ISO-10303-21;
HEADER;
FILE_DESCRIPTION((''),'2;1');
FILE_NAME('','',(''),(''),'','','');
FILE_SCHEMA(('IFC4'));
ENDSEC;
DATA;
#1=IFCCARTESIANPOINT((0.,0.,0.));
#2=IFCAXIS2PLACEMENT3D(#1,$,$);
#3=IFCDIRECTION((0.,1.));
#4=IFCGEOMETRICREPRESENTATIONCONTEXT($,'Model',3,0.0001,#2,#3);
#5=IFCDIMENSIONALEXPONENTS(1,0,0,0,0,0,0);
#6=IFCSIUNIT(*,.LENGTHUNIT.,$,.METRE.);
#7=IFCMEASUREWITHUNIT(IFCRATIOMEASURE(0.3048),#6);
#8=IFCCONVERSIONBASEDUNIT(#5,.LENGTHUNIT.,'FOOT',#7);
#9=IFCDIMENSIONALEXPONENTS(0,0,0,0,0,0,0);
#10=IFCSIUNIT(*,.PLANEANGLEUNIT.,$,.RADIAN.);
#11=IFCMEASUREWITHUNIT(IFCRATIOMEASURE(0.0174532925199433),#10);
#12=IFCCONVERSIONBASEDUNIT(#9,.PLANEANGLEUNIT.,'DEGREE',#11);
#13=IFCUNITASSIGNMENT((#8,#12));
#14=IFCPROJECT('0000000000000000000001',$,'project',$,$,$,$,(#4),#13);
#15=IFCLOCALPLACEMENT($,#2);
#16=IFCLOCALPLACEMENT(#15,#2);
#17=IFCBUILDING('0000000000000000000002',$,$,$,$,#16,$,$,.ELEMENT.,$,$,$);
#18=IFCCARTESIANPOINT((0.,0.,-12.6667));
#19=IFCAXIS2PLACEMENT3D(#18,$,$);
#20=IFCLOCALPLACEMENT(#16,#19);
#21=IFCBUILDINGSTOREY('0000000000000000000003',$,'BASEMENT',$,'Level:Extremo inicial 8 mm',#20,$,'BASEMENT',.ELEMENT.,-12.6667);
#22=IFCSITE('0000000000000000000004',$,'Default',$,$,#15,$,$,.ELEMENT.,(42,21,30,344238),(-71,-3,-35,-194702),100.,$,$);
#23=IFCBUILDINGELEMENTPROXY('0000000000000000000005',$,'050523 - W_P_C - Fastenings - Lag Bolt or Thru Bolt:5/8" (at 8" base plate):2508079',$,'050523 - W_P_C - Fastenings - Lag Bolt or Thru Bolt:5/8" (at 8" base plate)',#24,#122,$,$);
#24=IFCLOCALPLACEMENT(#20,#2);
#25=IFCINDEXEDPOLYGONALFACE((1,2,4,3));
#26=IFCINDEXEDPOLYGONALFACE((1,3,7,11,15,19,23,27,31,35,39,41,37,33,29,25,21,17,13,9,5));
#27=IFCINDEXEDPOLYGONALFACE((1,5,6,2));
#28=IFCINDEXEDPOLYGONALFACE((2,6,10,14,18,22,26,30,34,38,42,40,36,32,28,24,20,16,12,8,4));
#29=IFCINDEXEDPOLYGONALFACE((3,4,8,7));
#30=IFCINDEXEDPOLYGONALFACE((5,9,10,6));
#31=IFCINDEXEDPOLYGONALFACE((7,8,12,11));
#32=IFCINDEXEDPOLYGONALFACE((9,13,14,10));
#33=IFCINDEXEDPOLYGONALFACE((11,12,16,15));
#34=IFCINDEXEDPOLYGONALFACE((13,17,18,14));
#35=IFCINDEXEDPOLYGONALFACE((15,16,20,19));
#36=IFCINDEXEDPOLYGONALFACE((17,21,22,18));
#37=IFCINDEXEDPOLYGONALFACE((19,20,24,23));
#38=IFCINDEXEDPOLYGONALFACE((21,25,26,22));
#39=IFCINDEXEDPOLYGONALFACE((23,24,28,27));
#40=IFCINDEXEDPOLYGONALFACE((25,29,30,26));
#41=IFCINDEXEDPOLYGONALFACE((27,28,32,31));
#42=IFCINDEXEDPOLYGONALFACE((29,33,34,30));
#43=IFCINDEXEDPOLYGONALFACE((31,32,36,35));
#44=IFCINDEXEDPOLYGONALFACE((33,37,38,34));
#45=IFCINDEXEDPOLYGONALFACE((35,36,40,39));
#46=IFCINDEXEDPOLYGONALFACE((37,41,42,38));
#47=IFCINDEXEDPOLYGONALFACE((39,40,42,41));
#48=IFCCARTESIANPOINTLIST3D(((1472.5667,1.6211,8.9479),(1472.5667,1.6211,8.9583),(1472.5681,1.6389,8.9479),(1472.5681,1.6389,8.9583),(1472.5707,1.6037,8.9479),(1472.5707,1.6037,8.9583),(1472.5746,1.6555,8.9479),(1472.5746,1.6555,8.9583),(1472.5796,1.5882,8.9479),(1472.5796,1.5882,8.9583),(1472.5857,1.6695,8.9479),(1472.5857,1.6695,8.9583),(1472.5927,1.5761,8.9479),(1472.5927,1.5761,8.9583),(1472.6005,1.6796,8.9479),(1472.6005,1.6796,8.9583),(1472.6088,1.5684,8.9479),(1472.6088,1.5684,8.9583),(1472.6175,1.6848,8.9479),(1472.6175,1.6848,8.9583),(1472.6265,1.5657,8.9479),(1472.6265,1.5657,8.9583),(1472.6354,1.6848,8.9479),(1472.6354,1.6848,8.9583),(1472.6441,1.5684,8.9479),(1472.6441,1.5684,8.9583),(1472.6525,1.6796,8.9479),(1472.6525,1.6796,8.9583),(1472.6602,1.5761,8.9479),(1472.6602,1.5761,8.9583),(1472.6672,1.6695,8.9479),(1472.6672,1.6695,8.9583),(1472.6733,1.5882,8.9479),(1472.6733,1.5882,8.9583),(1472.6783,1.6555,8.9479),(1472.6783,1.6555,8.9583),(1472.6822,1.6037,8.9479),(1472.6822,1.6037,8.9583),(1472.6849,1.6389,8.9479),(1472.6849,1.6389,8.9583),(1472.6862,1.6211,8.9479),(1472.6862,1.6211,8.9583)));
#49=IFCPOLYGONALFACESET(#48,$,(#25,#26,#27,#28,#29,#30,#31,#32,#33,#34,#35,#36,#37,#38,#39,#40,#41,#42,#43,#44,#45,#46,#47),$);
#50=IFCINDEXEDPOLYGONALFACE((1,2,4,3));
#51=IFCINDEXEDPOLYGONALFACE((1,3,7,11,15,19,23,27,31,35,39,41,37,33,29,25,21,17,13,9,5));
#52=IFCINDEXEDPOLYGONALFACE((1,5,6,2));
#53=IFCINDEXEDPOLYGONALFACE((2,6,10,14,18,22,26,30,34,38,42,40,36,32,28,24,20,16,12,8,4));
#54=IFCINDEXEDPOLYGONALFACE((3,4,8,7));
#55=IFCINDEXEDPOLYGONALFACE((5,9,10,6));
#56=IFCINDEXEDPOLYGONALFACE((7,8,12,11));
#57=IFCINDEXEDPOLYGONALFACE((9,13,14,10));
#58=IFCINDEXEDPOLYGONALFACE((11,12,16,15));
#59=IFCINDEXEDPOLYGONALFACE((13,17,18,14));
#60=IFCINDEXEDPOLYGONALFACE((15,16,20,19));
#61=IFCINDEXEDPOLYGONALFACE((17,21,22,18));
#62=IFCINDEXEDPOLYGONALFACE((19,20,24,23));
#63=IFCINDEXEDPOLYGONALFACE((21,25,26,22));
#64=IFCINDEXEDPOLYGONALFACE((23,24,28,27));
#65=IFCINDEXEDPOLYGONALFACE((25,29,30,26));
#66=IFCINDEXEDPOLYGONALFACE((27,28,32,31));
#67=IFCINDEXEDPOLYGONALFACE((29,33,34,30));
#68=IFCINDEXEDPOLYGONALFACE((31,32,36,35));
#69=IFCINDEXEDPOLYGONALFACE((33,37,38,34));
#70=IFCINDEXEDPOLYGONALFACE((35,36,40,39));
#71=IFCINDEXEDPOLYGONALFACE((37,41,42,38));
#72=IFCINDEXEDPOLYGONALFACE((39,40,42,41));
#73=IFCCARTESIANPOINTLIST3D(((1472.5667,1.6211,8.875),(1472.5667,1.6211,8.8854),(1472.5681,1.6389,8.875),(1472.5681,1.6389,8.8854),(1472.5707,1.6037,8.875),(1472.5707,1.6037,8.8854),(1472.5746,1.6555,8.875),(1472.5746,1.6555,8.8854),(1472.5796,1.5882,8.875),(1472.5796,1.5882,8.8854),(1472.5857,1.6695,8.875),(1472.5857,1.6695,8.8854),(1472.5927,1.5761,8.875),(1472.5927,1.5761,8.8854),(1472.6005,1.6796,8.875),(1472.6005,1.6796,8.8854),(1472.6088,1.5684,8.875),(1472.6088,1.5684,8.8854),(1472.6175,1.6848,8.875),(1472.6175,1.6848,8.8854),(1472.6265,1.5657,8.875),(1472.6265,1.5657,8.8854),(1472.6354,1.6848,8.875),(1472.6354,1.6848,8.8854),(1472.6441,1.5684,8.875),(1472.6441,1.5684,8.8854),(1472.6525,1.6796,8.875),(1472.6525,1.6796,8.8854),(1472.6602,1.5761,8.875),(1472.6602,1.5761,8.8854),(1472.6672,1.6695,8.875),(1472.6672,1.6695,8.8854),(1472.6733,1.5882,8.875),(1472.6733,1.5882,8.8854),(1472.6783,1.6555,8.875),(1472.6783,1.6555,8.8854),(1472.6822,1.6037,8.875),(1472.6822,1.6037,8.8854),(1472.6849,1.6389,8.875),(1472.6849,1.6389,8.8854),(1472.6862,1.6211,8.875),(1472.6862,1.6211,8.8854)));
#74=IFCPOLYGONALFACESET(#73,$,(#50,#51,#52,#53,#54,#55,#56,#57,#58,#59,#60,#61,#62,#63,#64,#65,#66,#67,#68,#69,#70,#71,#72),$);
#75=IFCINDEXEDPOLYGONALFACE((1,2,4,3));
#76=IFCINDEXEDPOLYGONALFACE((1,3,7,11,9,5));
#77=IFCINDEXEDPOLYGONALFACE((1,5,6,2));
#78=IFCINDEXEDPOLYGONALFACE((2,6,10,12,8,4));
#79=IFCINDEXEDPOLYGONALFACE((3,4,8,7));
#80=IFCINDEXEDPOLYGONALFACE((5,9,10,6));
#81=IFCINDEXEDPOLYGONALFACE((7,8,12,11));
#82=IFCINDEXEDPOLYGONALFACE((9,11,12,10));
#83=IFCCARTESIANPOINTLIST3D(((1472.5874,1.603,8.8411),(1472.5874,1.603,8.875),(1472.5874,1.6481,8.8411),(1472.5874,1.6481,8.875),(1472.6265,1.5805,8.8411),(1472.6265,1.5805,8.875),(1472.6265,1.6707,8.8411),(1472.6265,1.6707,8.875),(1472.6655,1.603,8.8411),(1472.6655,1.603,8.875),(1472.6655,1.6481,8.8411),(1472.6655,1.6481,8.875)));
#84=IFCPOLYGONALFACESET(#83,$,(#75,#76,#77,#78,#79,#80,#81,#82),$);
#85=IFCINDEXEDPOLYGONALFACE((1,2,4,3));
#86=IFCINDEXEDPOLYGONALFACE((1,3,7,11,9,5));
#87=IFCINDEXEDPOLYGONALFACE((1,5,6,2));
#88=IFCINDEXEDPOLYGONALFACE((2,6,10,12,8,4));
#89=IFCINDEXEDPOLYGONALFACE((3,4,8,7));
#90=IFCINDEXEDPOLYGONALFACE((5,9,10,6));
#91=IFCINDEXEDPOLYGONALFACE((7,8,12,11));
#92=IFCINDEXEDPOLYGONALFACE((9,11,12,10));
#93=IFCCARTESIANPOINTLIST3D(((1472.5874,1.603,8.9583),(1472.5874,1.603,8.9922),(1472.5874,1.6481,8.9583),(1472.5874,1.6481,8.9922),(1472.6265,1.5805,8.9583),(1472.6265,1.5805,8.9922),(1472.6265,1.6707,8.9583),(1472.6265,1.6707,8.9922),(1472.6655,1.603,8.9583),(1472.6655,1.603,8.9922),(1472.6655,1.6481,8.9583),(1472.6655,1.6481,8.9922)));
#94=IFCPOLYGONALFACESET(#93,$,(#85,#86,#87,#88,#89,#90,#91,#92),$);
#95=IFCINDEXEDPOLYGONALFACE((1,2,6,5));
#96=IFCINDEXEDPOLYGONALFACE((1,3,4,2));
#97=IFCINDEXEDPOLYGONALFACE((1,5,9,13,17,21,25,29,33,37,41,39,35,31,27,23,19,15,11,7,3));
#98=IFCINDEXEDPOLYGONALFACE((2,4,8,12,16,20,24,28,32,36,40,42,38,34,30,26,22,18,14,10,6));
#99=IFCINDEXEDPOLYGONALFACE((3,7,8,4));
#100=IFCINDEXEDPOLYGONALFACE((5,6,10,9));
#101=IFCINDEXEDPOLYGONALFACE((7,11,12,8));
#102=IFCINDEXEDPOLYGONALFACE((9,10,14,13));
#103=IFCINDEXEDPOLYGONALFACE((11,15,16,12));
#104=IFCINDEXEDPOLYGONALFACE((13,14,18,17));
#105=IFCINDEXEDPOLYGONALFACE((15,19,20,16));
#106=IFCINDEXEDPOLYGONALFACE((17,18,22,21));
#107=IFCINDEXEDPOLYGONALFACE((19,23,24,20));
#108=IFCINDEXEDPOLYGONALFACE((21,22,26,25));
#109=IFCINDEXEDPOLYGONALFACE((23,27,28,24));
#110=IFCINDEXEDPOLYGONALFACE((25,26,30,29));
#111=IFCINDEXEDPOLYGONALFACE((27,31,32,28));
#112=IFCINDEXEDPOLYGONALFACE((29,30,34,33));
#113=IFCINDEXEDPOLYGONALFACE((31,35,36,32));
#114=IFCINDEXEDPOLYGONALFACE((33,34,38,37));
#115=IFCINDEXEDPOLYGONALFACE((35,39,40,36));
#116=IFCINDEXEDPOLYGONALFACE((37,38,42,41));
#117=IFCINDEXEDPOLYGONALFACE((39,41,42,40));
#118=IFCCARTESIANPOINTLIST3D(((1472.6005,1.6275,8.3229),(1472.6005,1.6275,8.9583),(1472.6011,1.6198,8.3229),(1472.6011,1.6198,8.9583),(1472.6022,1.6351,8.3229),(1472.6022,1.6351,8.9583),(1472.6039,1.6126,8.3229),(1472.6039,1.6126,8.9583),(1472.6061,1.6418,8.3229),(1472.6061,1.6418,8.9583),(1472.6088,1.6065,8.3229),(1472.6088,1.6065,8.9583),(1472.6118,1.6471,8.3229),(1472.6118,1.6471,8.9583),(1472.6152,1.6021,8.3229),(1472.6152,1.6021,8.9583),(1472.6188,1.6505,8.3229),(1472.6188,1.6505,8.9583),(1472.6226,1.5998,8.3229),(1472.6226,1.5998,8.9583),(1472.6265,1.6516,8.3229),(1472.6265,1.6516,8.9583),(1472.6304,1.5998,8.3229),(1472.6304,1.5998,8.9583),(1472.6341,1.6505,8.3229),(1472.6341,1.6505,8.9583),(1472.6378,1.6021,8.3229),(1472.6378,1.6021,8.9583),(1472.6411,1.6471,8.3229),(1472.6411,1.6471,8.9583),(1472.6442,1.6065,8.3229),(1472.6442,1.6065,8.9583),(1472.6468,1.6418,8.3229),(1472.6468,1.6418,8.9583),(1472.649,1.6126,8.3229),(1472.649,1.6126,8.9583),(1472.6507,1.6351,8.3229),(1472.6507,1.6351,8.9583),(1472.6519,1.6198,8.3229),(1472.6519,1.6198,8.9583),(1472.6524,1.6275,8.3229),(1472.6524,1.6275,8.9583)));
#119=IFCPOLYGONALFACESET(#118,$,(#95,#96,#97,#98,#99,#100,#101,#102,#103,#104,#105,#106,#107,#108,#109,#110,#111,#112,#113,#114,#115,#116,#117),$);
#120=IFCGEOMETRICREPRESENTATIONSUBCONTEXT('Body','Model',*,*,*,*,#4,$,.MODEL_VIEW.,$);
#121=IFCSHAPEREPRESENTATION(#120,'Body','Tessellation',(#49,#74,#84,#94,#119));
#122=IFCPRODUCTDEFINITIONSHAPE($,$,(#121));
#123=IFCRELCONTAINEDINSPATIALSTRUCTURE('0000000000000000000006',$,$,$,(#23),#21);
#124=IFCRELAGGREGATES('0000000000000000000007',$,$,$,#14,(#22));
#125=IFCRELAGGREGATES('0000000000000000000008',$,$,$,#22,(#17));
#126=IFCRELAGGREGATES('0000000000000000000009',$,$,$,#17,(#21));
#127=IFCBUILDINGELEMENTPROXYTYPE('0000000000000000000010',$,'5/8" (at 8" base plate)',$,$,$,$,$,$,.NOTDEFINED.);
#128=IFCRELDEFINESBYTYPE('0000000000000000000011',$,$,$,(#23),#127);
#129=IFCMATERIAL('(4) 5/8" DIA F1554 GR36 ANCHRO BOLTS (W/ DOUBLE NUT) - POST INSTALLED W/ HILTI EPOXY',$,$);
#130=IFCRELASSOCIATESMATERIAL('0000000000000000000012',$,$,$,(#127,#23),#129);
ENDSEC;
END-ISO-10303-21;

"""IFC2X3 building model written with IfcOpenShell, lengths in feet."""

from ifc_helpers import new_model, entity, si_unit, converted_unit, direction, frame, frame_2d, origin, place, context, subcontext, project, spatial, polyline, circle, outline, extrude, source, transform, mapped, material, type_object, type_shapes, element, save


model = new_model("IFC2X3")

# Units and contexts
model_context = context("Model", 3, precision=0.0001, world=origin(), true_north=direction((0.0, 1.0)))
body_context = subcontext(model_context, "Body", "Model", "MODEL_VIEW")
ifc_project = project(units=[converted_unit("LENGTHUNIT", "FOOT", entity("IfcRatioMeasure", 0.3048), si_unit("LENGTHUNIT", "METRE"), dimensions=[1, 0, 0, 0, 0, 0, 0]), converted_unit("PLANEANGLEUNIT", "DEGREE", entity("IfcRatioMeasure", 0.0174532925199433), si_unit("PLANEANGLEUNIT", "RADIAN"), dimensions=[0, 0, 0, 0, 0, 0, 0])], contexts=[model_context])

# Site, building, storey
site_placement = place(None, origin())
site = spatial("IfcSite", under=ifc_project, at=site_placement, Name="Default", CompositionType="ELEMENT", RefLatitude=(42, 21, 30, 344238), RefLongitude=(-71, -3, -35, -194702), RefElevation=100.0)
building_placement = place(site_placement, origin())
building = spatial("IfcBuilding", under=site, at=building_placement, CompositionType="ELEMENT")
storey_placement = place(building_placement, frame((0.0, 0.0, -12.6667)))
storey = spatial("IfcBuildingStorey", under=building, at=storey_placement, Name="BASEMENT", ObjectType="Level:Extremo inicial 8 mm", LongName="BASEMENT", CompositionType="ELEMENT", Elevation=-12.6667)

# Building element proxy
ifc_material_1 = material(Name="(4) 5/8\" DIA F1554 GR36 ANCHRO BOLTS (W/ DOUBLE NUT) - POST INSTALLED W/ HILTI EPOXY")
building_element_proxy_type_1 = type_object("IfcBuildingElementProxyType", Name="5/8\" (at 8\" base plate)", PredefinedType="NOTDEFINED", material=ifc_material_1)
shared_shape_1 = source(origin(), body_context, "Body", "SweptSolid", [
    extrude(circle(Radius=0.0599, at=frame_2d((0.0, 0.0), x_axis=(1.0, 0.0))), frame((0.0, 0.0, 0.0), z_axis=(0.0, 0.0, 1.0), x_axis=(0.0, -1.0, 0.0)), (0.0, 0.0, 1.0), 0.0104),
    extrude(circle(Radius=0.0599, at=frame_2d((0.0, 0.0), x_axis=(1.0, 0.0))), frame((0.0, 0.0, -0.0729), z_axis=(0.0, 0.0, 1.0), x_axis=(0.0, -1.0, 0.0)), (0.0, 0.0, 1.0), 0.0104),
    extrude(outline(polyline([(-0.0226, -0.0391), (0.0226, -0.0391), (0.0451, 0.0), (0.0226, 0.0391), (-0.0226, 0.0391), (-0.0451, 0.0), (-0.0226, -0.0391)])), frame((0.0, 0.0, -0.1068), z_axis=(0.0, 0.0, 1.0), x_axis=(0.866025, -0.5, 0.0)), (0.0, 0.0, 1.0), 0.0339),
    extrude(outline(polyline([(-0.0226, -0.0391), (0.0226, -0.0391), (0.0451, 0.0), (0.0226, 0.0391), (-0.0226, 0.0391), (-0.0451, 0.0), (-0.0226, -0.0391)])), frame((0.0, 0.0, 0.0104), z_axis=(0.0, 0.0, 1.0), x_axis=(0.0, -1.0, 0.0)), (0.0, 0.0, 1.0), 0.0339),
    extrude(circle(Radius=0.026, at=frame_2d((0.0, 0.0), x_axis=(1.0, 0.0))), frame((0.0, 0.0, -0.625), z_axis=(0.0, 0.0, 1.0), x_axis=(0.0, 1.0, 0.0)), (0.0, 0.0, 1.0), 0.6354),
])
type_shapes(building_element_proxy_type_1, [shared_shape_1])
for number, where, name in (
    (1, (1472.6265, 1.6256, 8.9479), "050523 - W_P_C - Fastenings - Lag Bolt or Thru Bolt:5/8\" (at 8\" base plate):2508079"),
):
    element("IfcBuildingElementProxy", number, at=place(storey_placement, frame(where)), inside=storey, type_object=building_element_proxy_type_1, material=ifc_material_1, Name=name, ObjectType="050523 - W_P_C - Fastenings - Lag Bolt or Thru Bolt:5/8\" (at 8\" base plate)", context=body_context, shape_type="MappedRepresentation", body=[
        mapped(shared_shape_1, transform((0.0, 0.0, 0.0), scale=1.0)),
    ])

save(model, "model.ifc")
